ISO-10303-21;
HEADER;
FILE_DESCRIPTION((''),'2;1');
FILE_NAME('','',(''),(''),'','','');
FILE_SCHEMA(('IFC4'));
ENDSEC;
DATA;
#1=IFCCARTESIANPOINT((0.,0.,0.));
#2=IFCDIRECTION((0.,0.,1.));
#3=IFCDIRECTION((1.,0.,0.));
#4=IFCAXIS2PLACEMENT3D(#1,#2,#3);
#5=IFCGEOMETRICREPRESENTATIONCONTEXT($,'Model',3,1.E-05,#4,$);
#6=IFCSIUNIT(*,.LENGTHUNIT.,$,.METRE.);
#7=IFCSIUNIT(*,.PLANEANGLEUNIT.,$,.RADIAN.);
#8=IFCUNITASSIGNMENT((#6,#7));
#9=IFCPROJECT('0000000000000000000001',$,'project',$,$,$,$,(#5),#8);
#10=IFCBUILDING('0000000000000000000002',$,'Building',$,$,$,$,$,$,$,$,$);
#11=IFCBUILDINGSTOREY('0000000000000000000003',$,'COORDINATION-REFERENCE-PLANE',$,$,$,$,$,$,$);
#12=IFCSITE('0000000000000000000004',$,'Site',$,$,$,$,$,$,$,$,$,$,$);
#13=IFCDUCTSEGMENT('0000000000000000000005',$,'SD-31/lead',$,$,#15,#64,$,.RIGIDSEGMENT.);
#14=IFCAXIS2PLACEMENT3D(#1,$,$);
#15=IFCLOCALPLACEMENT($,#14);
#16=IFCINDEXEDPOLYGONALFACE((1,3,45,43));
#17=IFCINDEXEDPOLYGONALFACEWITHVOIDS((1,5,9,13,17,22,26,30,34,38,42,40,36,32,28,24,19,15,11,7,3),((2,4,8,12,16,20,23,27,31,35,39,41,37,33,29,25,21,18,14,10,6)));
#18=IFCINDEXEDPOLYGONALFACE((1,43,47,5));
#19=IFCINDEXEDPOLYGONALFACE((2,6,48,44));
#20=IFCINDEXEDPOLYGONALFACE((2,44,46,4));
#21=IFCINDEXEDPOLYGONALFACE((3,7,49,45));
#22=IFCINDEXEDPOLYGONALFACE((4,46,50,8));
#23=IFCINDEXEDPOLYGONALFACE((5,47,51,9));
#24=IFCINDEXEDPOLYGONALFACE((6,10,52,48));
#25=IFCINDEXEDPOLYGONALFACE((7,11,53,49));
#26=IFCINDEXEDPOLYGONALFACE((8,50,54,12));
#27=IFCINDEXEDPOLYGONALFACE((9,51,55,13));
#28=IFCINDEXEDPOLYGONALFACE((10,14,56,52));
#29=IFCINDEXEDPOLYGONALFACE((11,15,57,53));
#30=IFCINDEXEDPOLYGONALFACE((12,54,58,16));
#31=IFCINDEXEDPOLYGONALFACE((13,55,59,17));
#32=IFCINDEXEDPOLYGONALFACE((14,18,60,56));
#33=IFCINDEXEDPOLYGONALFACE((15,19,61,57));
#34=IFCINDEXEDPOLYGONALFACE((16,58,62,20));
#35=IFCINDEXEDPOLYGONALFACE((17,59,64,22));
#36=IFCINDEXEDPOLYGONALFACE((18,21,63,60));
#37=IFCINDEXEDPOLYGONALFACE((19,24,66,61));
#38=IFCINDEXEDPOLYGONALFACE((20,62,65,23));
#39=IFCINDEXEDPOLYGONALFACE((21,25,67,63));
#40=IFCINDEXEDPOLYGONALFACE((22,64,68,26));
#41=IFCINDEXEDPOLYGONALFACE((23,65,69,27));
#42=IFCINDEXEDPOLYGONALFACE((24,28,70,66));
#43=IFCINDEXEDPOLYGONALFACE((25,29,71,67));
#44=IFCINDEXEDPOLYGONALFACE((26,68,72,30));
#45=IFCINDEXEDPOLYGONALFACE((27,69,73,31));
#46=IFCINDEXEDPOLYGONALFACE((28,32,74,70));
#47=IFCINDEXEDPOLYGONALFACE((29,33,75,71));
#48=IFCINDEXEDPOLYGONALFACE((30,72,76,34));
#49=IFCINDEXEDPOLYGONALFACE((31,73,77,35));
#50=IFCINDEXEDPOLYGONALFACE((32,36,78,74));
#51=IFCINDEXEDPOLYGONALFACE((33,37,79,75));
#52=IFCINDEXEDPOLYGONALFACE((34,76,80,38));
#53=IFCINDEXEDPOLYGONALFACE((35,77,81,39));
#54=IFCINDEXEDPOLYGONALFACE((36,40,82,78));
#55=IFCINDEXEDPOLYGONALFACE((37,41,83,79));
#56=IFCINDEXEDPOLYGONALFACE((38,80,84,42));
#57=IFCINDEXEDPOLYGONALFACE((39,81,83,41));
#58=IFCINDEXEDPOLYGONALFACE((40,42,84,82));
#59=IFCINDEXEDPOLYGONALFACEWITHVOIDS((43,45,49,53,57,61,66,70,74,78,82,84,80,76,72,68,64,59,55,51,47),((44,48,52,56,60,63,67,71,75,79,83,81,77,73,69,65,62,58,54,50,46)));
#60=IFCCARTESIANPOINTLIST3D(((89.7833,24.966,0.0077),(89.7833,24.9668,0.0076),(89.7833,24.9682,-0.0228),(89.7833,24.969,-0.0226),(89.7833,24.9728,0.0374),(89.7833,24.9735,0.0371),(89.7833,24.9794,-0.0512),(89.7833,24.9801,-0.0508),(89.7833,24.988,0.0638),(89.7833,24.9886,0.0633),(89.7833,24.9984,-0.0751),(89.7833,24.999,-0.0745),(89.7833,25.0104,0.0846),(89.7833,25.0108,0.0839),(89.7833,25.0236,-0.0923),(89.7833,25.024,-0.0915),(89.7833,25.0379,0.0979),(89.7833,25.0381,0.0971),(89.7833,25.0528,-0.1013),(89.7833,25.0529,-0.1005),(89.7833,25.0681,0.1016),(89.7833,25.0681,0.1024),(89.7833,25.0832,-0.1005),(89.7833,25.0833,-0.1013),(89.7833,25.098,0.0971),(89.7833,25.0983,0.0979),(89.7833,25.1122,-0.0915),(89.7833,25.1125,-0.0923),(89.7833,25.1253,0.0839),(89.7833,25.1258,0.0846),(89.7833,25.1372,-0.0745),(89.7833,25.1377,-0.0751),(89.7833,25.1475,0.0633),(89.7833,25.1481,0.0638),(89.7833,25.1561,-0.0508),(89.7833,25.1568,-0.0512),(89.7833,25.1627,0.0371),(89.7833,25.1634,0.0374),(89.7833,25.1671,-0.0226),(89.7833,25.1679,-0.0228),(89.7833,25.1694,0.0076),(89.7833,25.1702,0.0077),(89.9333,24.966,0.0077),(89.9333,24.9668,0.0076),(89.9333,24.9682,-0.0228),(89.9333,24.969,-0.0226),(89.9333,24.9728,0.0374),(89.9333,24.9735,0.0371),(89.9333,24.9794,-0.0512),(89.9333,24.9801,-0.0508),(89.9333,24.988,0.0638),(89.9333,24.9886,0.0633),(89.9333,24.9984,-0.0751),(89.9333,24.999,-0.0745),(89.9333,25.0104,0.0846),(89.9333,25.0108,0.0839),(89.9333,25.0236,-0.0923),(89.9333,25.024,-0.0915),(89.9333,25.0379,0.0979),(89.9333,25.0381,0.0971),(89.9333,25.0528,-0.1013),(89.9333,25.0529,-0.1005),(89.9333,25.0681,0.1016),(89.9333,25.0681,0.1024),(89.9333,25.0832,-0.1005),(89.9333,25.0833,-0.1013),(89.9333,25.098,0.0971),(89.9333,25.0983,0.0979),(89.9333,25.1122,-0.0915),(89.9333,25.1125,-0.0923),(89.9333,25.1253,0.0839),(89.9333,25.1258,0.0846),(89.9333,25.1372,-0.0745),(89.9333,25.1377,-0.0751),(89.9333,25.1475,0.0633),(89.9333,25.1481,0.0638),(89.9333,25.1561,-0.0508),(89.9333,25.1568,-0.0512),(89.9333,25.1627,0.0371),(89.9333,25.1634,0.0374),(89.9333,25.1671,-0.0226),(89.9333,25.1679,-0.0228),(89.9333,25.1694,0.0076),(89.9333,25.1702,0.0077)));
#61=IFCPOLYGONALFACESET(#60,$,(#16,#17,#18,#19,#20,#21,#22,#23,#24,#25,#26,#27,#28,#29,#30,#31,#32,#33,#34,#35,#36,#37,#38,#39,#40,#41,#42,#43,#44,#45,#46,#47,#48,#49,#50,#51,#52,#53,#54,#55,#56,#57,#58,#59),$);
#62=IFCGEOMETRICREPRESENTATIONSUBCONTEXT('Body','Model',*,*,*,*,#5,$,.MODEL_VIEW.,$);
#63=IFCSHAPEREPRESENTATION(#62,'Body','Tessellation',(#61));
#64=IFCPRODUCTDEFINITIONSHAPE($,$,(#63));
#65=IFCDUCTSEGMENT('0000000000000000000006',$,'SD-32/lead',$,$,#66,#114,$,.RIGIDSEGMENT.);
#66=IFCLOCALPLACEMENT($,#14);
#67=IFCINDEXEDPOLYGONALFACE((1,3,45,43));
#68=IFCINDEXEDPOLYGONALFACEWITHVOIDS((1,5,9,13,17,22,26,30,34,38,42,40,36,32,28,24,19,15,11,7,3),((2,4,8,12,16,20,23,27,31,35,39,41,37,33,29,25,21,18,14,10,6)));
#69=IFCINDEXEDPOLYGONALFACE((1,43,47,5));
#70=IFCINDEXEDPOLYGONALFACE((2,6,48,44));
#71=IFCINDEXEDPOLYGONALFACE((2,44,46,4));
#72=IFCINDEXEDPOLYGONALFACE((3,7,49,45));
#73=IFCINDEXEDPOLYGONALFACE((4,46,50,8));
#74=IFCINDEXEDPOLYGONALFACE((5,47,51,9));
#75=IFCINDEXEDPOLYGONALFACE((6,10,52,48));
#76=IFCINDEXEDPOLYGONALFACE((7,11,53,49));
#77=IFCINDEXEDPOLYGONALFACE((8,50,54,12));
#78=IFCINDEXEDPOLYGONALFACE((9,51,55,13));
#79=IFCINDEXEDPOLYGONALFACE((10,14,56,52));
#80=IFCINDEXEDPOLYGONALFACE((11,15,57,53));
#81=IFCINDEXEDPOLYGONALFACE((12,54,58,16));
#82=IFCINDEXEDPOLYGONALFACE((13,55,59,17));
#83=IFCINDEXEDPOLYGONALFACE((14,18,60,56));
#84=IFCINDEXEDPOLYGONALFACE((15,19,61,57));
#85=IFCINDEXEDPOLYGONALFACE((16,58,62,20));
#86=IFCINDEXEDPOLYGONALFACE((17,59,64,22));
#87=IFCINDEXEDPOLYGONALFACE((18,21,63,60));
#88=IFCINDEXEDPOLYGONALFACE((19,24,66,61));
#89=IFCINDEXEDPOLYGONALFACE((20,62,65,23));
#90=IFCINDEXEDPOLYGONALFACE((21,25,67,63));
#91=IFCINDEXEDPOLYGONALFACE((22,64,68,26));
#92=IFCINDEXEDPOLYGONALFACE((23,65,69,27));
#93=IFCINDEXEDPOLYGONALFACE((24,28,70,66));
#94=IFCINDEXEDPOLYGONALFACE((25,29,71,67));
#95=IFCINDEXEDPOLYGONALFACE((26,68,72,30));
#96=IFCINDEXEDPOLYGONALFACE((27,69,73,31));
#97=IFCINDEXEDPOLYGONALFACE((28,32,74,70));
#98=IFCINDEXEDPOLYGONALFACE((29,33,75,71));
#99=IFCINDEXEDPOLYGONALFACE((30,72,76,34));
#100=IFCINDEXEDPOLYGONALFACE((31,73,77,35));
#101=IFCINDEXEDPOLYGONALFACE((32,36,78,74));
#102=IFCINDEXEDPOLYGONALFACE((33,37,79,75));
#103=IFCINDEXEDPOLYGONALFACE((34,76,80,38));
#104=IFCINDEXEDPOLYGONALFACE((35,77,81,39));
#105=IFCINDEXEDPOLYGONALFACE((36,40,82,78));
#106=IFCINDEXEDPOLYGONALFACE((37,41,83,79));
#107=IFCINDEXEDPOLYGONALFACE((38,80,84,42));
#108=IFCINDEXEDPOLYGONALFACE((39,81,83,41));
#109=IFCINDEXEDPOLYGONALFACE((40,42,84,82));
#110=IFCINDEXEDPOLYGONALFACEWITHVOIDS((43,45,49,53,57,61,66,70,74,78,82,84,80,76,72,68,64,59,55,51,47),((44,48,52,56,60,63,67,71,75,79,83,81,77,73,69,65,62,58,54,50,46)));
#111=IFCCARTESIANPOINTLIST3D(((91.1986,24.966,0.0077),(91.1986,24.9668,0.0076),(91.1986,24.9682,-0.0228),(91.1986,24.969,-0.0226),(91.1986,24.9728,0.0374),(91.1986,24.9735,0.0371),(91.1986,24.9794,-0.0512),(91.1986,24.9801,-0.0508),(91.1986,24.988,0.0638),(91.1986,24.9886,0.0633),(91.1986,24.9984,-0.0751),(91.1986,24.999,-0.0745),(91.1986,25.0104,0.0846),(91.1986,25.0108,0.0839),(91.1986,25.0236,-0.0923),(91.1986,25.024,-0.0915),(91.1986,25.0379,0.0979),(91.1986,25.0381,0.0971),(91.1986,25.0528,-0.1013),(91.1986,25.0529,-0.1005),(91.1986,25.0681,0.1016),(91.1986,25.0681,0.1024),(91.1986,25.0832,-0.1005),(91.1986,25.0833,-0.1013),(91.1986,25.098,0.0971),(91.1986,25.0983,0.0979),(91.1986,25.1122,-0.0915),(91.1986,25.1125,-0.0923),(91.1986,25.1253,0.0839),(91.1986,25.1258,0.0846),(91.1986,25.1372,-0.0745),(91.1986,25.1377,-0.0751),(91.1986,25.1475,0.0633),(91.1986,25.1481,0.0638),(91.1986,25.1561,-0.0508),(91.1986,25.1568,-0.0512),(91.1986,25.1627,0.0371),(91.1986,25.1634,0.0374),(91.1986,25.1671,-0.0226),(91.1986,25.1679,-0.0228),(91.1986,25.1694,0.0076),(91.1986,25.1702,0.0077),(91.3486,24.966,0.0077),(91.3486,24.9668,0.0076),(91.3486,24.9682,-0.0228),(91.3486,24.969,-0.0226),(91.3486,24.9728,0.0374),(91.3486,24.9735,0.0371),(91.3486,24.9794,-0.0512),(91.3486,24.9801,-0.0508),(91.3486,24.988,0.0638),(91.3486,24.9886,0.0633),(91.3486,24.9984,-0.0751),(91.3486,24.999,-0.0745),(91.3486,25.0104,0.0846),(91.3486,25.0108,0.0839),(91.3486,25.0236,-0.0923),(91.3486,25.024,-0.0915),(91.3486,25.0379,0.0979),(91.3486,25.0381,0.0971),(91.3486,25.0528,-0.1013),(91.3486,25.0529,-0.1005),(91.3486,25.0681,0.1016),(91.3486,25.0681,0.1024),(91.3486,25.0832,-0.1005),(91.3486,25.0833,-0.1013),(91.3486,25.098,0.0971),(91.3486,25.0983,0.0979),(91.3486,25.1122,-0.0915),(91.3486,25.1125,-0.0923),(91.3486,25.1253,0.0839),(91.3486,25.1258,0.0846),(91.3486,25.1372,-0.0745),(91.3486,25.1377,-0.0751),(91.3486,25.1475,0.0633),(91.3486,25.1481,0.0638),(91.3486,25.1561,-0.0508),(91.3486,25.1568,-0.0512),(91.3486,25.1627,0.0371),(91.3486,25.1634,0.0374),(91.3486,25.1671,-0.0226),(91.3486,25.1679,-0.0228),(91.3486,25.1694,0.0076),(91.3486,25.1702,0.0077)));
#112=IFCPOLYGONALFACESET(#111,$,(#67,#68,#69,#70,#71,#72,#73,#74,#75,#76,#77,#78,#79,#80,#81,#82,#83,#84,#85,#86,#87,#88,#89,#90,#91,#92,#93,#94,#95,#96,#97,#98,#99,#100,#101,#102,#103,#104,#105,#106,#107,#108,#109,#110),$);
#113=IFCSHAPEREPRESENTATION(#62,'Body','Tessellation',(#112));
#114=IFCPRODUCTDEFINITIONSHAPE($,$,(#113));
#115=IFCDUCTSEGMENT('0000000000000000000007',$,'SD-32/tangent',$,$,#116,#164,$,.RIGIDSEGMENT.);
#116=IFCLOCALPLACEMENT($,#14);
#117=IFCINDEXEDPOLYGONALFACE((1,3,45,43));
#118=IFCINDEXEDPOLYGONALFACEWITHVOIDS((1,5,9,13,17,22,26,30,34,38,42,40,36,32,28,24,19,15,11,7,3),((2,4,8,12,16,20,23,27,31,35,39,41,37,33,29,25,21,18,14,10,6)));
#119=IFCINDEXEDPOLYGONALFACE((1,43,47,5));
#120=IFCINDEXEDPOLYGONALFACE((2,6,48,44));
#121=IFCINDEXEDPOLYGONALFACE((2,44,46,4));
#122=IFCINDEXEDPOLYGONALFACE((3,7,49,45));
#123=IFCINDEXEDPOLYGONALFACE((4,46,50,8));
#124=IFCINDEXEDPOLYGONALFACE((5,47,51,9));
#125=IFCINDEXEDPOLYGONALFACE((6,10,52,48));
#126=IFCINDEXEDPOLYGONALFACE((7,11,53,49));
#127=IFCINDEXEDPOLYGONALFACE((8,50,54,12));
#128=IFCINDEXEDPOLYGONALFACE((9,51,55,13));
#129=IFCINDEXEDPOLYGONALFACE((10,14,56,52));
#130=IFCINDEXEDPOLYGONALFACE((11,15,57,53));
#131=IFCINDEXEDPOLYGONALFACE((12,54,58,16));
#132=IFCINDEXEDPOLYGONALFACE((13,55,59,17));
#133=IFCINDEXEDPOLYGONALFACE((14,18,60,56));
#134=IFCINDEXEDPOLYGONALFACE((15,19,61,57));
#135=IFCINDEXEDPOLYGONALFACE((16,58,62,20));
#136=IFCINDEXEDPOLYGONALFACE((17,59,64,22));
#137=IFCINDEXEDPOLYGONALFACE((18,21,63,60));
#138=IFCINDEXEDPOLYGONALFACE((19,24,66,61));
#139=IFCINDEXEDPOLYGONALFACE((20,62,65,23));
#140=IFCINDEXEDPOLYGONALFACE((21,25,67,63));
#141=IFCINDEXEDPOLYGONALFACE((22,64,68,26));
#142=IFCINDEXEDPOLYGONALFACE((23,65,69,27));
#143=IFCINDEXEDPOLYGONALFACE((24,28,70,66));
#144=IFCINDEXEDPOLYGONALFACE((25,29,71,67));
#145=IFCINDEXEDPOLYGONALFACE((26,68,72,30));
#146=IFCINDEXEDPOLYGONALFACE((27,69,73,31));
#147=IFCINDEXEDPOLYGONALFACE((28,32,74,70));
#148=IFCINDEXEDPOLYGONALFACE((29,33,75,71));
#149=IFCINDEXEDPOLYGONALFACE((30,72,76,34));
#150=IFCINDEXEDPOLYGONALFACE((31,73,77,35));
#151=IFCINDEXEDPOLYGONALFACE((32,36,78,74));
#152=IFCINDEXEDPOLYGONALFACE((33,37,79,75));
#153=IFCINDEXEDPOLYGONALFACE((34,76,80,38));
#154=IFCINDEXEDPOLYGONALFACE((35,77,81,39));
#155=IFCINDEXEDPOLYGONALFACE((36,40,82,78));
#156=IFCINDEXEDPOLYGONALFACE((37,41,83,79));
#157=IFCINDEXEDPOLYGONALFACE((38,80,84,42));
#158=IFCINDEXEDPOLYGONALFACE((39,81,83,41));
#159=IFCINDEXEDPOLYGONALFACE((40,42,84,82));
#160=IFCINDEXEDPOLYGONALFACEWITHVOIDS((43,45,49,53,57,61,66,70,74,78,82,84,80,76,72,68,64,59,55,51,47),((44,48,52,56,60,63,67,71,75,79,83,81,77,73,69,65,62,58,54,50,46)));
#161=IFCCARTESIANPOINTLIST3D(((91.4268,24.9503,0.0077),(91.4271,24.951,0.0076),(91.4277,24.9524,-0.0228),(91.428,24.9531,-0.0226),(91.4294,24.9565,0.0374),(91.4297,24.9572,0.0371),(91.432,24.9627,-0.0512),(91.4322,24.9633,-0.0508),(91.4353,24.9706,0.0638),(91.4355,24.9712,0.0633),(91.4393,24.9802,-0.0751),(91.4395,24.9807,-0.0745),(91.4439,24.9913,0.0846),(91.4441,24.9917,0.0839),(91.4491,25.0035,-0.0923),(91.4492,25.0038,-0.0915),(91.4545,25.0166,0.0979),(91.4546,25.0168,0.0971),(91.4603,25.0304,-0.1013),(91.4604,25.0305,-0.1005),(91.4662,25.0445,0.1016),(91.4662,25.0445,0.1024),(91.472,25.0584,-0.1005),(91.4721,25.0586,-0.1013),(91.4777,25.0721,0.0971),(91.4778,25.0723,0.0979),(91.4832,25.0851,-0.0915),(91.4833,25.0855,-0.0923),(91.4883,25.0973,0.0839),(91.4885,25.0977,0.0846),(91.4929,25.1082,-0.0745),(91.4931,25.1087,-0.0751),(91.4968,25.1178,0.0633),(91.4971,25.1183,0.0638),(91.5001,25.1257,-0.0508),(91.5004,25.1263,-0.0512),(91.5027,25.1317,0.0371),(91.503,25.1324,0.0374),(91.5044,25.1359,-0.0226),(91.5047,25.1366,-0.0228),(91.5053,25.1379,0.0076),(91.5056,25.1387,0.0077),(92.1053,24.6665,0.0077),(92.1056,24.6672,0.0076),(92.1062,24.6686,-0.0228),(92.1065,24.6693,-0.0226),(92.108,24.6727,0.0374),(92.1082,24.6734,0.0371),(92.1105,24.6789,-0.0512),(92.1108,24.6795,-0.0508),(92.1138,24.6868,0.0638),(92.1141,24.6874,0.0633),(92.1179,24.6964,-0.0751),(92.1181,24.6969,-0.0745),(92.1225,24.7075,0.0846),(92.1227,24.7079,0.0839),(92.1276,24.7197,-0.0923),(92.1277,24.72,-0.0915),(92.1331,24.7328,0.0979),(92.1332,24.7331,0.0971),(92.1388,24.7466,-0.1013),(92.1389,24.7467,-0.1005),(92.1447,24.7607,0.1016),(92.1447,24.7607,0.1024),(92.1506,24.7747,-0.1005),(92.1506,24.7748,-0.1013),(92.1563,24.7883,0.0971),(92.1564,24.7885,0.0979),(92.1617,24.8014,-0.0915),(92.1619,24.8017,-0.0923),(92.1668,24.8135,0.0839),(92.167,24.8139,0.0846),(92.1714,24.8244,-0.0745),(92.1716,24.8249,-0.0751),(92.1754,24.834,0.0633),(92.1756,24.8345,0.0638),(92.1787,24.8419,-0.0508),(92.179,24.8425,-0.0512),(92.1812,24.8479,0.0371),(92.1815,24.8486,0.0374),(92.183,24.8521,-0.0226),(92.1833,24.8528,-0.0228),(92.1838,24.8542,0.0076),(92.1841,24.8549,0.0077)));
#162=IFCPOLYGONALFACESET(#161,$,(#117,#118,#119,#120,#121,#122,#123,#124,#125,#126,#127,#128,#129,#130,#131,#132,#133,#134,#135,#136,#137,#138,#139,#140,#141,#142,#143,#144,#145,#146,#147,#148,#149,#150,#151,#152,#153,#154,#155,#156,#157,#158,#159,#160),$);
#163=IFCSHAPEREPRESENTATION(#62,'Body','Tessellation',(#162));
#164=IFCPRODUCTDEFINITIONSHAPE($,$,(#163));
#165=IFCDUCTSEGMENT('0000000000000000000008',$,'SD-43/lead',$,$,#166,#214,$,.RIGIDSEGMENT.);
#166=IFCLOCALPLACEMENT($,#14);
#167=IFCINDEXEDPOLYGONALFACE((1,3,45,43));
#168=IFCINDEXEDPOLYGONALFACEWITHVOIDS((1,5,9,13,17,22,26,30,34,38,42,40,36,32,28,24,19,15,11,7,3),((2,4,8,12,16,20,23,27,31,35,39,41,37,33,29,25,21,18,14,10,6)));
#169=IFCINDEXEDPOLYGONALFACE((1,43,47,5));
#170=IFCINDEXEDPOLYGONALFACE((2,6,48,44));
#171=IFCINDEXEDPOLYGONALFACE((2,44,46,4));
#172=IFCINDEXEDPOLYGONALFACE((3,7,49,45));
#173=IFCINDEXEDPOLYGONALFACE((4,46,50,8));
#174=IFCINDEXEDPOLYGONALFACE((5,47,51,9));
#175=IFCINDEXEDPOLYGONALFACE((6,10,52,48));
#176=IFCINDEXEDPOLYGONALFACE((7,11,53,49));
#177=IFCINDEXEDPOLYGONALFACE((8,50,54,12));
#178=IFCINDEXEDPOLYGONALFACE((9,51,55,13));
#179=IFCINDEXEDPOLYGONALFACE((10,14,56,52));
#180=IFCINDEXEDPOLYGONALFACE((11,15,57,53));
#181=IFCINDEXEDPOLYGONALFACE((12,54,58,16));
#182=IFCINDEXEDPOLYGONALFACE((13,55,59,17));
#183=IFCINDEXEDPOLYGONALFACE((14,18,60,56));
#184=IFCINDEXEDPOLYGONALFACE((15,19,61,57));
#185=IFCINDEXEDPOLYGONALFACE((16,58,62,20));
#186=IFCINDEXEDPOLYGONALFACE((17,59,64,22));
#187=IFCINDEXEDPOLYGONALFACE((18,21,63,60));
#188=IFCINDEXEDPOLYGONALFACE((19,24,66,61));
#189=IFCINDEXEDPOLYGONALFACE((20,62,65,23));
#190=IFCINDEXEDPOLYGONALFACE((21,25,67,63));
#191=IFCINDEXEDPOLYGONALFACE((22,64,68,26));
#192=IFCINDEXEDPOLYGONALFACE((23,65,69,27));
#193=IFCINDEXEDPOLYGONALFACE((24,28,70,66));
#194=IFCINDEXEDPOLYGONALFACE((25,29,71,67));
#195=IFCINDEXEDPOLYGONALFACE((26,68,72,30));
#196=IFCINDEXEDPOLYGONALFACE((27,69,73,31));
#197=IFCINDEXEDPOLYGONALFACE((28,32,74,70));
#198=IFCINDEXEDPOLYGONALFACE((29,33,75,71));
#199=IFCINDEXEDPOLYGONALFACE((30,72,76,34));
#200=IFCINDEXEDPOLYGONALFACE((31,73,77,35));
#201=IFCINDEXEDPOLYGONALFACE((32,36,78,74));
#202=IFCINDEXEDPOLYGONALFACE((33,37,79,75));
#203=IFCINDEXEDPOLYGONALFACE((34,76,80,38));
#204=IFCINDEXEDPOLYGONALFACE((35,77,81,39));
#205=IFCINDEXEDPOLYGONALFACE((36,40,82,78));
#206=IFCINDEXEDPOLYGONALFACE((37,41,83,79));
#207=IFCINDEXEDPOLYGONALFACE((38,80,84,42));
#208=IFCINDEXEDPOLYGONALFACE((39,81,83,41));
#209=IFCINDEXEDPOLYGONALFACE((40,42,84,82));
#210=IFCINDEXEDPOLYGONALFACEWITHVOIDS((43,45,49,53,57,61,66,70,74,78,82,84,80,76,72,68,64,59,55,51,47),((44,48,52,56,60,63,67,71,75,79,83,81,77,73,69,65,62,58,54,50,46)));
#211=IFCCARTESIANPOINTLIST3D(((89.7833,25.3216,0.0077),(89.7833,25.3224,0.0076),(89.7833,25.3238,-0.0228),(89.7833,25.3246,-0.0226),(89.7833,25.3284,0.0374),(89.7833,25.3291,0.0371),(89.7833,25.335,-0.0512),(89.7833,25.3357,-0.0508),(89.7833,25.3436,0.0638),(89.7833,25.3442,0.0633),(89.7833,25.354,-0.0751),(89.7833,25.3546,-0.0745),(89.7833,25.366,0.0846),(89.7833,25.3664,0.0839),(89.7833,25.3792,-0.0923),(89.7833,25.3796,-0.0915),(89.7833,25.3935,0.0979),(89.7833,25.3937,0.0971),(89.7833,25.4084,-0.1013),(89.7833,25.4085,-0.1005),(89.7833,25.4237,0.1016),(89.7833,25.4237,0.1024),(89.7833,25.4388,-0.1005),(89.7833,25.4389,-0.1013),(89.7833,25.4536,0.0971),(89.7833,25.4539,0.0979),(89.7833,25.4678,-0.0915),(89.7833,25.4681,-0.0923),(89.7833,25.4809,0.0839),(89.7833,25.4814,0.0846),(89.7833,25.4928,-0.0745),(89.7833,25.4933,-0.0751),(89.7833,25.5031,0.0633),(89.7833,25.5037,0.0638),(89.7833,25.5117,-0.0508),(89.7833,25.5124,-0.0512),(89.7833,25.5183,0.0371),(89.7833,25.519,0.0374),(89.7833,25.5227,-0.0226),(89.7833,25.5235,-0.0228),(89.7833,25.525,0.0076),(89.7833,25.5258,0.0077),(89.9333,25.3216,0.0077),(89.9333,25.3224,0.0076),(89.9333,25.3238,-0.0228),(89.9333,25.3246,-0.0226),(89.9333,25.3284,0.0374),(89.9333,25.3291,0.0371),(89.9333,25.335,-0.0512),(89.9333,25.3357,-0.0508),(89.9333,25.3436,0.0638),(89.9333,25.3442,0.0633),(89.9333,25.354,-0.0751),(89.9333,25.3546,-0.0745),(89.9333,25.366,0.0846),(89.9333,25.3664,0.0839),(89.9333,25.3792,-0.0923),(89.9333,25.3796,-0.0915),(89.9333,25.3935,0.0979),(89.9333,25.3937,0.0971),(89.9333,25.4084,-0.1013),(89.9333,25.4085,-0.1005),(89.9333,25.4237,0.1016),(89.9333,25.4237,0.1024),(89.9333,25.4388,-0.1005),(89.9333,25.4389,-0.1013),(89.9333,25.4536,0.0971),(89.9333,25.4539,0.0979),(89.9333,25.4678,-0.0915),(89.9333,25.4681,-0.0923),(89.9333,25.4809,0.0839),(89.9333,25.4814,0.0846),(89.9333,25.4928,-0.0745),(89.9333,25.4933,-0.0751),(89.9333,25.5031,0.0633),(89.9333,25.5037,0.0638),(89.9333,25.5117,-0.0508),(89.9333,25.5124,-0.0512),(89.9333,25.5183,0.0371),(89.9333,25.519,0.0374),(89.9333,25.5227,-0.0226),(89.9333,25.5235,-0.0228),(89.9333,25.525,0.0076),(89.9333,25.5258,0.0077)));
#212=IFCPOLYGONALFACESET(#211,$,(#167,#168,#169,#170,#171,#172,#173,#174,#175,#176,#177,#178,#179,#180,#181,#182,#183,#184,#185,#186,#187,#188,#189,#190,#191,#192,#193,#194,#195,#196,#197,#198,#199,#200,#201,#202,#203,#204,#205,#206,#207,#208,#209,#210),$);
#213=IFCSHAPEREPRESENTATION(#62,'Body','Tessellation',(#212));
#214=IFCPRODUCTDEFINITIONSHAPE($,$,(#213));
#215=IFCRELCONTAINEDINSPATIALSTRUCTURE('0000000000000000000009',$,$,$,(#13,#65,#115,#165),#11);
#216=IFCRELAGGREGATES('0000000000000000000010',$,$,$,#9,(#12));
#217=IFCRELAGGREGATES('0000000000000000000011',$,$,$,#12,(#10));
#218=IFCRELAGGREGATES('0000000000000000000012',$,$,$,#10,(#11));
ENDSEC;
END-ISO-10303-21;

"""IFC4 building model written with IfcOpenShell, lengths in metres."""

from ifc_helpers import new_model, si_unit, frame, origin_with_axes, place, context, subcontext, project, spatial, hollow_circle, extrude, element, save


model = new_model("IFC4")

# Units and contexts
model_context_1 = context("Model", 3, precision=1e-05, world=origin_with_axes())
body_context_1 = subcontext(model_context_1, "Body", "Model", "MODEL_VIEW")
ifc_project = project(units=[si_unit("LENGTHUNIT", "METRE"), si_unit("PLANEANGLEUNIT", "RADIAN")], contexts=[model_context_1])

# Site, building, storey
site = spatial("IfcSite", under=ifc_project, Name="Site")
building = spatial("IfcBuilding", under=site, Name="Building")
storey = spatial("IfcBuildingStorey", under=building, Name="COORDINATION-REFERENCE-PLANE")

# Duct segments
for number, where, z_axis, x_axis, name in (
    (1, (89.9333, 25.0681, 0.0), (-1.0, 0.0, 0.0), (0.0, 0.0, 1.0), "SD-31/lead"),
    (2, (91.1986, 25.0681, 0.0), (1.0, 0.0, 0.0), (0.0, 0.0, 1.0), "SD-32/lead"),
):
    element("IfcDuctSegment", number, at=place(None, frame(where, z_axis=z_axis, x_axis=x_axis)), inside=storey, Name=name, PredefinedType="RIGIDSEGMENT", context=body_context_1, shape_type="SweptSolid", body=[
        extrude(hollow_circle(Radius=0.1024, WallThickness=0.0008), origin_with_axes(), (0.0, 0.0, 1.0), 0.15),
    ])

# Duct segment
duct_segment_1_placement = place(None, frame((91.4662, 25.0445, 0.0), z_axis=(0.922564, -0.385845, 0.0), x_axis=(0.0, 0.0, 1.0)))
element("IfcDuctSegment", 3, at=duct_segment_1_placement, inside=storey, Name="SD-32/tangent", PredefinedType="RIGIDSEGMENT", context=body_context_1, shape_type="SweptSolid", body=[
    extrude(hollow_circle(Radius=0.1024, WallThickness=0.0008), origin_with_axes(), (0.0, 0.0, 1.0), 0.7355),
])

# Duct segment
for number, where, z_axis, x_axis, name in (
    (4, (89.9333, 25.4237, 0.0), (-1.0, 0.0, 0.0), (0.0, 0.0, 1.0), "SD-43/lead"),
):
    element("IfcDuctSegment", number, at=place(None, frame(where, z_axis=z_axis, x_axis=x_axis)), inside=storey, Name=name, PredefinedType="RIGIDSEGMENT", context=body_context_1, shape_type="SweptSolid", body=[
        extrude(hollow_circle(Radius=0.1024, WallThickness=0.0008), origin_with_axes(), (0.0, 0.0, 1.0), 0.15),
    ])

save(model, "model.ifc")
